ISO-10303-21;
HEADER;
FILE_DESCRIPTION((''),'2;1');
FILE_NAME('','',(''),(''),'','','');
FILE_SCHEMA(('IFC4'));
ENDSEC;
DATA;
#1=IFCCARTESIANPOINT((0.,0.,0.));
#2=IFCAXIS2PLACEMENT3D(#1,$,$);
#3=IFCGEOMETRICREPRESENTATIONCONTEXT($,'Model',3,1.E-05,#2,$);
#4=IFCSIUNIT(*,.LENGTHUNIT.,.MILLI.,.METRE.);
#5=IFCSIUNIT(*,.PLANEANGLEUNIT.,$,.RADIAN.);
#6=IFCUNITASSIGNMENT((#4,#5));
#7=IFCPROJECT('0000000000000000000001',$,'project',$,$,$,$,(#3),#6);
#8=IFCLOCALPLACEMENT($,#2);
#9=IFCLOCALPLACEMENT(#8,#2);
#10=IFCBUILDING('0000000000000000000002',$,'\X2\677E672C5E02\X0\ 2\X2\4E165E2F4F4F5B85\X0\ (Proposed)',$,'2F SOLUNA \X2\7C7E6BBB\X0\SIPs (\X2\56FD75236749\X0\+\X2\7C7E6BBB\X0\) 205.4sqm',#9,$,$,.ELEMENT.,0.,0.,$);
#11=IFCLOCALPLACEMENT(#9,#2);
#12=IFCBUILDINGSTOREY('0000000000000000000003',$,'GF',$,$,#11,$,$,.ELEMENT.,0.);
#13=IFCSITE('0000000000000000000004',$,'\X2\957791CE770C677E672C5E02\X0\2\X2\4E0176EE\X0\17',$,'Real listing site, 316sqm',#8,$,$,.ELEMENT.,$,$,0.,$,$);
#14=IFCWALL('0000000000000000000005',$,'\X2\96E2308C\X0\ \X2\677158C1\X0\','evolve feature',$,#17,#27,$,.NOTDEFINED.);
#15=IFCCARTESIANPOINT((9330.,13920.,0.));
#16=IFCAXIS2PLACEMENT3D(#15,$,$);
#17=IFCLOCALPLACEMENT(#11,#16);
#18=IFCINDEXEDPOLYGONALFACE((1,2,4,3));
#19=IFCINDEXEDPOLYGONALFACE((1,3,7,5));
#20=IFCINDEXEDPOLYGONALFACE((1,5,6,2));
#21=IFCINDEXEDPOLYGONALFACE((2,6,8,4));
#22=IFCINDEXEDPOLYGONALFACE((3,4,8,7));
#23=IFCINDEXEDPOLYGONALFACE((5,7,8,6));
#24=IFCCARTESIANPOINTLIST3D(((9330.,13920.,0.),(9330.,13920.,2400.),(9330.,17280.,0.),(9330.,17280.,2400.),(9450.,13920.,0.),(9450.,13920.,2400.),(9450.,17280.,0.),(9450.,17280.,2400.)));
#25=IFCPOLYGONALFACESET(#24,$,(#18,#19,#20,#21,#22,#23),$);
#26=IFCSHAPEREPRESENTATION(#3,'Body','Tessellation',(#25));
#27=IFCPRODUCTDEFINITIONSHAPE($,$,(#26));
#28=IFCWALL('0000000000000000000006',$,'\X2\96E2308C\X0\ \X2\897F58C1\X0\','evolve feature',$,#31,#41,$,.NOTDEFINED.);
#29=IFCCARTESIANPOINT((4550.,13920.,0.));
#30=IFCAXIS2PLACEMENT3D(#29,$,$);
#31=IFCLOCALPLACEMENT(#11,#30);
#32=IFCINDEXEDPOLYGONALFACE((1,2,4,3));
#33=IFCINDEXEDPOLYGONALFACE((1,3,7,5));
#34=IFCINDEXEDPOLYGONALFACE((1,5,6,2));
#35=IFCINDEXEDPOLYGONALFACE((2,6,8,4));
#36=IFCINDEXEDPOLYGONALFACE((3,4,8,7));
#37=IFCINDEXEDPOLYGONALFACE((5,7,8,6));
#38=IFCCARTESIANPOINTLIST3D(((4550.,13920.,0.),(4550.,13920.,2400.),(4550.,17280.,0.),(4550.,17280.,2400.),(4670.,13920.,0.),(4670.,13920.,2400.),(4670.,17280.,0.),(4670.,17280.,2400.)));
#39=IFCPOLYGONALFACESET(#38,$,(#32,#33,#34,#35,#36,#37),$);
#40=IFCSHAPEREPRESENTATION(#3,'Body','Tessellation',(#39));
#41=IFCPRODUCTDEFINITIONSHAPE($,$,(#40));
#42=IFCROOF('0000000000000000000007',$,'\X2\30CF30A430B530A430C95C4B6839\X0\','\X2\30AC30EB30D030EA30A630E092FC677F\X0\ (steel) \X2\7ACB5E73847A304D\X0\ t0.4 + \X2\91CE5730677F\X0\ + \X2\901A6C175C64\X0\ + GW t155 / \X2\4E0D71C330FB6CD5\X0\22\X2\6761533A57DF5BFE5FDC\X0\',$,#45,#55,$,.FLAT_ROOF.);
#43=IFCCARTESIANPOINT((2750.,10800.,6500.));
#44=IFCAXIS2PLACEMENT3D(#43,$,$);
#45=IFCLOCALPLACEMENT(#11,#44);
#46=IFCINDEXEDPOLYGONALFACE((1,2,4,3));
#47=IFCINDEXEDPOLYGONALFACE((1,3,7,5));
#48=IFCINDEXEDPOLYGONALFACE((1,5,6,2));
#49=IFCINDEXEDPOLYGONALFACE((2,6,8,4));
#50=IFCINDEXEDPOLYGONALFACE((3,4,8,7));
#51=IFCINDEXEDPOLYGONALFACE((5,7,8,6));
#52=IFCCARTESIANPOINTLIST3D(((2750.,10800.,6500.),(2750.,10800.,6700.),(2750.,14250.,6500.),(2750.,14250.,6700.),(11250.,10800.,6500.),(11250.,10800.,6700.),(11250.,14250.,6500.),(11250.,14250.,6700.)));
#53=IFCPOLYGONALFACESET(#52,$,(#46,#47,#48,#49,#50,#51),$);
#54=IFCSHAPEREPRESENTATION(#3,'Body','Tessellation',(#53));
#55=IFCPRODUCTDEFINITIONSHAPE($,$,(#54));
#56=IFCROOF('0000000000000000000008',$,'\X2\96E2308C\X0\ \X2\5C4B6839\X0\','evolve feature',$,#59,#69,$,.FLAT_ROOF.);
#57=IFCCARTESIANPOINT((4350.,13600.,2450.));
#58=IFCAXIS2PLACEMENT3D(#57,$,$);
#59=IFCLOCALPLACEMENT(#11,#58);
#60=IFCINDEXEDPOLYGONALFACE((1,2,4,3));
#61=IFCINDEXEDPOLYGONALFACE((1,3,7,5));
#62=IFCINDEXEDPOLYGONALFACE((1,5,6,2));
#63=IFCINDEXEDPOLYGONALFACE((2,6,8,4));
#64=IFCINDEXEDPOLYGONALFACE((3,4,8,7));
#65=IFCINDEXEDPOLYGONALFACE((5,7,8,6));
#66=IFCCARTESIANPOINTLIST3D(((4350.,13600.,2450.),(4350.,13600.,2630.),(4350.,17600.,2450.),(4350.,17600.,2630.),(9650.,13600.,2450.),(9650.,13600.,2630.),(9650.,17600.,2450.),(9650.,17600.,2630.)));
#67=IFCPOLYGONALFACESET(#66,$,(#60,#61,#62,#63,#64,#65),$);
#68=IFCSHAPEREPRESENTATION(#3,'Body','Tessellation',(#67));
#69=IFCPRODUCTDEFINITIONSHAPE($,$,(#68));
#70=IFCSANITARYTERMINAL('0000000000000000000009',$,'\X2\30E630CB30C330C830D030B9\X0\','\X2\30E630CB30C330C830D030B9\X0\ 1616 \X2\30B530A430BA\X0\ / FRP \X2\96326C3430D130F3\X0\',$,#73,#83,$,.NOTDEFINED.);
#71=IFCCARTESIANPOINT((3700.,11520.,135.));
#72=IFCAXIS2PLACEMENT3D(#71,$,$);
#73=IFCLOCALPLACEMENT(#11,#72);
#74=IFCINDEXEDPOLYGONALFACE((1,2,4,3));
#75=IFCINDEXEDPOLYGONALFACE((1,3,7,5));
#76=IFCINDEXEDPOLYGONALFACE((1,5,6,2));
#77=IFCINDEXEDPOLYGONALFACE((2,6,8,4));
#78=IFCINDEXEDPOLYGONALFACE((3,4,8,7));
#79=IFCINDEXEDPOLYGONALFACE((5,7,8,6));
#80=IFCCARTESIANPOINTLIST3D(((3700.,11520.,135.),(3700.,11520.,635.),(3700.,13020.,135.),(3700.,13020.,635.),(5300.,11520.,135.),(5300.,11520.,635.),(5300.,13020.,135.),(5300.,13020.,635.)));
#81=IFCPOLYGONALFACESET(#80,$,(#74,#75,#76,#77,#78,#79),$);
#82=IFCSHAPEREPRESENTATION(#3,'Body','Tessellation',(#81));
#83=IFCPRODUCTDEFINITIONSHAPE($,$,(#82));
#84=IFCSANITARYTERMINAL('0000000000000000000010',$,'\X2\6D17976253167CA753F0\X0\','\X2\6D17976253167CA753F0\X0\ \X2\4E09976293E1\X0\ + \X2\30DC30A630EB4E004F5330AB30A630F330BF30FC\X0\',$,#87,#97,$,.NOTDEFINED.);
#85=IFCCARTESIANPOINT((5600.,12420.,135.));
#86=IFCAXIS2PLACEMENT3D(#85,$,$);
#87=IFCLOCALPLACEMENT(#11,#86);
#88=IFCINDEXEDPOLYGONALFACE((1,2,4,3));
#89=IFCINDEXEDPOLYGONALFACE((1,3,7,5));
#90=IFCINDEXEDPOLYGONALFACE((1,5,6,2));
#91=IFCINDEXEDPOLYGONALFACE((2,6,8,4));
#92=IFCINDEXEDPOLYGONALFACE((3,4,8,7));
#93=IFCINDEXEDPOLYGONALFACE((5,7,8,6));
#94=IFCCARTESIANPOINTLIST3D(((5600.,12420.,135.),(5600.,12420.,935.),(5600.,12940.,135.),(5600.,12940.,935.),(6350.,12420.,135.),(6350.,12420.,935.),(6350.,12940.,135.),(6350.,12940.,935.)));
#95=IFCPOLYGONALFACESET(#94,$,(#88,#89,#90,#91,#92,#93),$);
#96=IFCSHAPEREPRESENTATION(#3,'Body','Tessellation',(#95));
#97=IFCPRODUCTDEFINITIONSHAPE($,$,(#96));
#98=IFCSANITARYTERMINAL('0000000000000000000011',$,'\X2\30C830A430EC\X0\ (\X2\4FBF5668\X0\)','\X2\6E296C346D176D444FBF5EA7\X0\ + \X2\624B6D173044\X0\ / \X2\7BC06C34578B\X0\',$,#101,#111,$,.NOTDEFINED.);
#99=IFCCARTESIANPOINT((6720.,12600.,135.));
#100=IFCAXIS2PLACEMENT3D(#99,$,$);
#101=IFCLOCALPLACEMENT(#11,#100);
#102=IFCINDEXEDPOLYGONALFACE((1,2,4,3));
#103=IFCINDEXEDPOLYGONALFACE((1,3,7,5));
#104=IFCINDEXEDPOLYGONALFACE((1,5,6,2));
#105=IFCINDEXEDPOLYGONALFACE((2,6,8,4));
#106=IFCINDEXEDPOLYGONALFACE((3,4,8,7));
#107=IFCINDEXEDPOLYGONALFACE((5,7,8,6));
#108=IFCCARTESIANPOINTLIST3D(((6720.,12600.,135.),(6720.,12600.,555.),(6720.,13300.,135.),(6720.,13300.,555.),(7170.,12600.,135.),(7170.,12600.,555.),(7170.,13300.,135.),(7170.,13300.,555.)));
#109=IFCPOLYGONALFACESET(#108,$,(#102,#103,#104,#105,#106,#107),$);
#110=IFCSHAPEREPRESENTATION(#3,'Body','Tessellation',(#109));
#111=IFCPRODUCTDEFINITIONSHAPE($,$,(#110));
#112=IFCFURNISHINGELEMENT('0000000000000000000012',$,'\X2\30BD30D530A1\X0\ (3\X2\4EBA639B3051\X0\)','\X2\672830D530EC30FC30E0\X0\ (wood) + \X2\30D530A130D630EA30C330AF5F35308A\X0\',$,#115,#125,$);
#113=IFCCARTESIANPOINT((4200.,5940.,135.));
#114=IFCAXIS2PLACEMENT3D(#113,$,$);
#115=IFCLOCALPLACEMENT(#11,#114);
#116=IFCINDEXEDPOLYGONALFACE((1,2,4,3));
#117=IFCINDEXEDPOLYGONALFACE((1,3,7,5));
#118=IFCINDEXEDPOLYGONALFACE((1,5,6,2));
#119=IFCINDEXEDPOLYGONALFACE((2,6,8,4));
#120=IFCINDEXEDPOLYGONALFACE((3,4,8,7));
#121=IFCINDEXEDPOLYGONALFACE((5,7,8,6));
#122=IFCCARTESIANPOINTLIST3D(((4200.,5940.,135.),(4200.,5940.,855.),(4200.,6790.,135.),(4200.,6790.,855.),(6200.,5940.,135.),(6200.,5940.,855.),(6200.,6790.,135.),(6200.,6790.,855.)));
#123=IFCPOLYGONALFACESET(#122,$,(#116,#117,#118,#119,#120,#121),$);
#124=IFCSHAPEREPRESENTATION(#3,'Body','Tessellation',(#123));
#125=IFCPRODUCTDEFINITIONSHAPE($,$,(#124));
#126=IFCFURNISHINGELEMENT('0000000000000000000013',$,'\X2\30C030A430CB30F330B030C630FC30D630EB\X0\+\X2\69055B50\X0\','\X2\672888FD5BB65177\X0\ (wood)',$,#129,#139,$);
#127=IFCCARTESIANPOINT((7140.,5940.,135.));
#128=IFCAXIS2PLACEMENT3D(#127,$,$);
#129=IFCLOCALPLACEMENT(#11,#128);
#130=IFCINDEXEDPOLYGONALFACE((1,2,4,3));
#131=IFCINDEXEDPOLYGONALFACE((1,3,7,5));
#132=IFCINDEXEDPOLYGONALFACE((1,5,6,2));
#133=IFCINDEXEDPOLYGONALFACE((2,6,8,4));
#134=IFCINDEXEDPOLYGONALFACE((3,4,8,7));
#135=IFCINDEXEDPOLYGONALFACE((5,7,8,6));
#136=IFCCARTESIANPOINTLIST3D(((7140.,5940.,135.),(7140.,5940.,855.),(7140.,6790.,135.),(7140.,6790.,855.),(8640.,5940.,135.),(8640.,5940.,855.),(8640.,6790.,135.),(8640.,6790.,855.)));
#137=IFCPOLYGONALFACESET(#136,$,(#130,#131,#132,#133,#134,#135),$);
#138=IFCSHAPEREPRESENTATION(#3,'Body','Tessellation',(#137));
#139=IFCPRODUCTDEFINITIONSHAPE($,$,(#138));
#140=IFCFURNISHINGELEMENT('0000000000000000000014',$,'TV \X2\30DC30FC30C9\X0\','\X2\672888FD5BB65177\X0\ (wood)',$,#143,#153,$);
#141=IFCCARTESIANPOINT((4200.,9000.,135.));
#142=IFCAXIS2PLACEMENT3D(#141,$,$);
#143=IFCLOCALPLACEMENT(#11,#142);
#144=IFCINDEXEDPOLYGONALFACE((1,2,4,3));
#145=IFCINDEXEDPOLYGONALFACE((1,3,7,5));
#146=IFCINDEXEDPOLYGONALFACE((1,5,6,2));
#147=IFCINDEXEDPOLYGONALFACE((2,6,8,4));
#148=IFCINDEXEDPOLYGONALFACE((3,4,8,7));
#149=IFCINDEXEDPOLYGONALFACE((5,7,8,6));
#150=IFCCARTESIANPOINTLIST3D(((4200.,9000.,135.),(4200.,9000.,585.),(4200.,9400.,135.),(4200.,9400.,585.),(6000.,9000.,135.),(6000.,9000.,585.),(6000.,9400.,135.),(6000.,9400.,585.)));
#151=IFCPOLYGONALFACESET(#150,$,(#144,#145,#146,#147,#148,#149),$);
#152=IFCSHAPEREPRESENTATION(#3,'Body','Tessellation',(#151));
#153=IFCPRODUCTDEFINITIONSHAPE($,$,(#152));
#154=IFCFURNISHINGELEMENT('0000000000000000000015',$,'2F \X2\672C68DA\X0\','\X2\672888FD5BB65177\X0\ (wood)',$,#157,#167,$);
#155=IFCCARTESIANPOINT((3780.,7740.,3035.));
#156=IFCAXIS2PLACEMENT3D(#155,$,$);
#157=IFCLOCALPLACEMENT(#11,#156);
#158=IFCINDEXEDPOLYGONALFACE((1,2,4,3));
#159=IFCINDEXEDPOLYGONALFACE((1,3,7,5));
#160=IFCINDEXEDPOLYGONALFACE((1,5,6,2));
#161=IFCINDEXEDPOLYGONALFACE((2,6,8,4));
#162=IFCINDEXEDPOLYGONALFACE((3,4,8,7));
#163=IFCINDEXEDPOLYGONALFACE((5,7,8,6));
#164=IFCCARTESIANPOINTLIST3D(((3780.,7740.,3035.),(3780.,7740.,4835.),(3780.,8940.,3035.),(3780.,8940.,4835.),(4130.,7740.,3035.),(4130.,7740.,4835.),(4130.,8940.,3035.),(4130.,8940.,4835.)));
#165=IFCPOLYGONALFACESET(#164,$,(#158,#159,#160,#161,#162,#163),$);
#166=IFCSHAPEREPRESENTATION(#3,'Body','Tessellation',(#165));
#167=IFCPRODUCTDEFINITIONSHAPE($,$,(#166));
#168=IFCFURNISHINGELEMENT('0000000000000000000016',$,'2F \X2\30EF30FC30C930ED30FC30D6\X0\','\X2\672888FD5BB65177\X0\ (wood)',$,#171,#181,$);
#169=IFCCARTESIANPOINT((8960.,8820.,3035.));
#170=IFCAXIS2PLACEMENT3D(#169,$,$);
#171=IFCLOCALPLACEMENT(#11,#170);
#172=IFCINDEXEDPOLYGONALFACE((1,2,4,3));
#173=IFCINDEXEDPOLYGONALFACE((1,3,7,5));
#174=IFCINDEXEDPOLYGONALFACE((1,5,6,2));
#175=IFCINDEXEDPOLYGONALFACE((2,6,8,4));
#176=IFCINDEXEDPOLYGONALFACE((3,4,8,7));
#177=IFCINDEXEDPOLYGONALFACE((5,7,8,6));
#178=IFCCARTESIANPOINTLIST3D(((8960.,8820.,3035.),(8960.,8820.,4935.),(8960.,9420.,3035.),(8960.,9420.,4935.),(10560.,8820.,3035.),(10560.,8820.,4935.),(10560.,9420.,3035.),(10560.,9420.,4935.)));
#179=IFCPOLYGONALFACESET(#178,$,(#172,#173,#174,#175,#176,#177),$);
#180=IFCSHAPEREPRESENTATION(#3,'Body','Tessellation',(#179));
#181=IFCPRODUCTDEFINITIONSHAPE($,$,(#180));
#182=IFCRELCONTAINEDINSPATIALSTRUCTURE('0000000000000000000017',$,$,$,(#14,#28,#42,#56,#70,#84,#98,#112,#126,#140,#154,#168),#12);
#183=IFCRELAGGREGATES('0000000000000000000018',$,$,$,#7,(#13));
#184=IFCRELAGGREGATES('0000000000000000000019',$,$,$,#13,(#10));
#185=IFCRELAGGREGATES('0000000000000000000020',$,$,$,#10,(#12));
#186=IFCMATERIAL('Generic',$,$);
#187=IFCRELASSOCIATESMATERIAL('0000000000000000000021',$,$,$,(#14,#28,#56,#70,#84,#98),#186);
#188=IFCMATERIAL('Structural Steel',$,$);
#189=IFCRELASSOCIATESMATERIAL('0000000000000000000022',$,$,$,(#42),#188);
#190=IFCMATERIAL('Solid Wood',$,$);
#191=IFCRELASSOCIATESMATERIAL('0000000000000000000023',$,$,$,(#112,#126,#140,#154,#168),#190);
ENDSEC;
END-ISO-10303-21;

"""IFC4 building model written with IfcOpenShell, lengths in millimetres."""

from ifc_helpers import new_model, si_unit, frame, frame_2d, origin, place, context, project, spatial, rectangle, extrude, material, element, save


model = new_model("IFC4")

# Units and contexts
model_context = context("Model", 3, precision=1e-05, world=origin())
ifc_project = project(units=[si_unit("LENGTHUNIT", "METRE", prefix="MILLI"), si_unit("PLANEANGLEUNIT", "RADIAN")], contexts=[model_context])

# Site, building, storey
site_placement = place(None, origin())
site = spatial("IfcSite", under=ifc_project, at=site_placement, Name="長野県松本市2丁目17", ObjectType="Real listing site, 316sqm", CompositionType="ELEMENT", RefElevation=0.0)
building_placement = place(site_placement, origin())
building = spatial("IfcBuilding", under=site, at=building_placement, Name="松本市 2世帯住宅 (Proposed)", ObjectType="2F SOLUNA 籾殻SIPs (国産杉+籾殻) 205.4sqm", CompositionType="ELEMENT", ElevationOfRefHeight=0.0, ElevationOfTerrain=0.0)
storey_placement = place(building_placement, origin())
storey = spatial("IfcBuildingStorey", under=building, at=storey_placement, Name="GF", CompositionType="ELEMENT", Elevation=0.0)

# Shared definitions
ifc_material_1 = material(Name="Generic")

# Shared definitions
ifc_material_2 = material(Name="Solid Wood")

# Walls
wall_1_placement = place(storey_placement, frame((9330.0, 13920.0, 0.0)))
element("IfcWall", 1, at=wall_1_placement, inside=storey, material=ifc_material_1, Name="離れ 東壁", Description="evolve feature", PredefinedType="NOTDEFINED", context=model_context, shape_type="SweptSolid", body=[
    extrude(rectangle(XDim=120.0, YDim=3360.0, at=frame_2d((60.0, 1680.0))), frame((9330.0, 13920.0, 0.0)), (0.0, 0.0, 1.0), 2400.0),
])
wall_2_placement = place(storey_placement, frame((4550.0, 13920.0, 0.0)))
element("IfcWall", 2, at=wall_2_placement, inside=storey, material=ifc_material_1, Name="離れ 西壁", Description="evolve feature", PredefinedType="NOTDEFINED", context=model_context, shape_type="SweptSolid", body=[
    extrude(rectangle(XDim=120.0, YDim=3360.0, at=frame_2d((60.0, 1680.0))), frame((4550.0, 13920.0, 0.0)), (0.0, 0.0, 1.0), 2400.0),
])

# Roofs
ifc_material_3 = material(Name="Structural Steel")
roof_1_placement = place(storey_placement, frame((2750.0, 10800.0, 6500.0)))
element("IfcRoof", 3, at=roof_1_placement, inside=storey, material=ifc_material_3, Name="ハイサイド屋根", Description="ガルバリウム鋼板 (steel) 立平葺き t0.4 + 野地板 + 通気層 + GW t155 / 不燃・法22条区域対応", PredefinedType="FLAT_ROOF", context=model_context, shape_type="SweptSolid", body=[
    extrude(rectangle(XDim=8500.0, YDim=3450.0, at=frame_2d((4250.0, 1725.0))), frame((2750.0, 10800.0, 6500.0)), (0.0, 0.0, 1.0), 200.0),
])
roof_2_placement = place(storey_placement, frame((4350.0, 13600.0, 2450.0)))
element("IfcRoof", 4, at=roof_2_placement, inside=storey, material=ifc_material_1, Name="離れ 屋根", Description="evolve feature", PredefinedType="FLAT_ROOF", context=model_context, shape_type="SweptSolid", body=[
    extrude(rectangle(XDim=5300.0, YDim=4000.0, at=frame_2d((2650.0, 2000.0))), frame((4350.0, 13600.0, 2450.0)), (0.0, 0.0, 1.0), 180.0),
])

# Sanitary terminals
sanitary_terminal_1_placement = place(storey_placement, frame((3700.0, 11520.0, 135.0)))
element("IfcSanitaryTerminal", 5, at=sanitary_terminal_1_placement, inside=storey, material=ifc_material_1, Name="ユニットバス", Description="ユニットバス 1616 サイズ / FRP 防水パン", PredefinedType="NOTDEFINED", context=model_context, shape_type="SweptSolid", body=[
    extrude(rectangle(XDim=1600.0, YDim=1500.0, at=frame_2d((800.0, 750.0))), frame((3700.0, 11520.0, 135.0)), (0.0, 0.0, 1.0), 500.0),
])
sanitary_terminal_2_placement = place(storey_placement, frame((5600.0, 12420.0, 135.0)))
element("IfcSanitaryTerminal", 6, at=sanitary_terminal_2_placement, inside=storey, material=ifc_material_1, Name="洗面化粧台", Description="洗面化粧台 三面鏡 + ボウル一体カウンター", PredefinedType="NOTDEFINED", context=model_context, shape_type="SweptSolid", body=[
    extrude(rectangle(XDim=750.0, YDim=520.0, at=frame_2d((375.0, 260.0))), frame((5600.0, 12420.0, 135.0)), (0.0, 0.0, 1.0), 800.0),
])
sanitary_terminal_3_placement = place(storey_placement, frame((6720.0, 12600.0, 135.0)))
element("IfcSanitaryTerminal", 7, at=sanitary_terminal_3_placement, inside=storey, material=ifc_material_1, Name="トイレ (便器)", Description="温水洗浄便座 + 手洗い / 節水型", PredefinedType="NOTDEFINED", context=model_context, shape_type="SweptSolid", body=[
    extrude(rectangle(XDim=450.0, YDim=700.0, at=frame_2d((225.0, 350.0))), frame((6720.0, 12600.0, 135.0)), (0.0, 0.0, 1.0), 420.0),
])

# Furnishing elements
furnishing_1_placement = place(storey_placement, frame((4200.0, 5940.0, 135.0)))
element("IfcFurnishingElement", 8, at=furnishing_1_placement, inside=storey, material=ifc_material_2, Name="ソファ (3人掛け)", Description="木フレーム (wood) + ファブリック張り", context=model_context, shape_type="SweptSolid", body=[
    extrude(rectangle(XDim=2000.0, YDim=850.0, at=frame_2d((1000.0, 425.0))), frame((4200.0, 5940.0, 135.0)), (0.0, 0.0, 1.0), 720.0),
])
furnishing_2_placement = place(storey_placement, frame((7140.0, 5940.0, 135.0)))
element("IfcFurnishingElement", 9, at=furnishing_2_placement, inside=storey, material=ifc_material_2, Name="ダイニングテーブル+椅子", Description="木製家具 (wood)", context=model_context, shape_type="SweptSolid", body=[
    extrude(rectangle(XDim=1500.0, YDim=850.0, at=frame_2d((750.0, 425.0))), frame((7140.0, 5940.0, 135.0)), (0.0, 0.0, 1.0), 720.0),
])
furnishing_3_placement = place(storey_placement, frame((4200.0, 9000.0, 135.0)))
element("IfcFurnishingElement", 10, at=furnishing_3_placement, inside=storey, material=ifc_material_2, Name="TV ボード", Description="木製家具 (wood)", context=model_context, shape_type="SweptSolid", body=[
    extrude(rectangle(XDim=1800.0, YDim=400.0, at=frame_2d((900.0, 200.0))), frame((4200.0, 9000.0, 135.0)), (0.0, 0.0, 1.0), 450.0),
])
furnishing_4_placement = place(storey_placement, frame((3780.0, 7740.0, 3035.0)))
element("IfcFurnishingElement", 11, at=furnishing_4_placement, inside=storey, material=ifc_material_2, Name="2F 本棚", Description="木製家具 (wood)", context=model_context, shape_type="SweptSolid", body=[
    extrude(rectangle(XDim=350.0, YDim=1200.0, at=frame_2d((175.0, 600.0))), frame((3780.0, 7740.0, 3035.0)), (0.0, 0.0, 1.0), 1800.0),
])
furnishing_5_placement = place(storey_placement, frame((8960.0, 8820.0, 3035.0)))
element("IfcFurnishingElement", 12, at=furnishing_5_placement, inside=storey, material=ifc_material_2, Name="2F ワードローブ", Description="木製家具 (wood)", context=model_context, shape_type="SweptSolid", body=[
    extrude(rectangle(XDim=1600.0, YDim=600.0, at=frame_2d((800.0, 300.0))), frame((8960.0, 8820.0, 3035.0)), (0.0, 0.0, 1.0), 1900.0),
])

save(model, "model.ifc")
